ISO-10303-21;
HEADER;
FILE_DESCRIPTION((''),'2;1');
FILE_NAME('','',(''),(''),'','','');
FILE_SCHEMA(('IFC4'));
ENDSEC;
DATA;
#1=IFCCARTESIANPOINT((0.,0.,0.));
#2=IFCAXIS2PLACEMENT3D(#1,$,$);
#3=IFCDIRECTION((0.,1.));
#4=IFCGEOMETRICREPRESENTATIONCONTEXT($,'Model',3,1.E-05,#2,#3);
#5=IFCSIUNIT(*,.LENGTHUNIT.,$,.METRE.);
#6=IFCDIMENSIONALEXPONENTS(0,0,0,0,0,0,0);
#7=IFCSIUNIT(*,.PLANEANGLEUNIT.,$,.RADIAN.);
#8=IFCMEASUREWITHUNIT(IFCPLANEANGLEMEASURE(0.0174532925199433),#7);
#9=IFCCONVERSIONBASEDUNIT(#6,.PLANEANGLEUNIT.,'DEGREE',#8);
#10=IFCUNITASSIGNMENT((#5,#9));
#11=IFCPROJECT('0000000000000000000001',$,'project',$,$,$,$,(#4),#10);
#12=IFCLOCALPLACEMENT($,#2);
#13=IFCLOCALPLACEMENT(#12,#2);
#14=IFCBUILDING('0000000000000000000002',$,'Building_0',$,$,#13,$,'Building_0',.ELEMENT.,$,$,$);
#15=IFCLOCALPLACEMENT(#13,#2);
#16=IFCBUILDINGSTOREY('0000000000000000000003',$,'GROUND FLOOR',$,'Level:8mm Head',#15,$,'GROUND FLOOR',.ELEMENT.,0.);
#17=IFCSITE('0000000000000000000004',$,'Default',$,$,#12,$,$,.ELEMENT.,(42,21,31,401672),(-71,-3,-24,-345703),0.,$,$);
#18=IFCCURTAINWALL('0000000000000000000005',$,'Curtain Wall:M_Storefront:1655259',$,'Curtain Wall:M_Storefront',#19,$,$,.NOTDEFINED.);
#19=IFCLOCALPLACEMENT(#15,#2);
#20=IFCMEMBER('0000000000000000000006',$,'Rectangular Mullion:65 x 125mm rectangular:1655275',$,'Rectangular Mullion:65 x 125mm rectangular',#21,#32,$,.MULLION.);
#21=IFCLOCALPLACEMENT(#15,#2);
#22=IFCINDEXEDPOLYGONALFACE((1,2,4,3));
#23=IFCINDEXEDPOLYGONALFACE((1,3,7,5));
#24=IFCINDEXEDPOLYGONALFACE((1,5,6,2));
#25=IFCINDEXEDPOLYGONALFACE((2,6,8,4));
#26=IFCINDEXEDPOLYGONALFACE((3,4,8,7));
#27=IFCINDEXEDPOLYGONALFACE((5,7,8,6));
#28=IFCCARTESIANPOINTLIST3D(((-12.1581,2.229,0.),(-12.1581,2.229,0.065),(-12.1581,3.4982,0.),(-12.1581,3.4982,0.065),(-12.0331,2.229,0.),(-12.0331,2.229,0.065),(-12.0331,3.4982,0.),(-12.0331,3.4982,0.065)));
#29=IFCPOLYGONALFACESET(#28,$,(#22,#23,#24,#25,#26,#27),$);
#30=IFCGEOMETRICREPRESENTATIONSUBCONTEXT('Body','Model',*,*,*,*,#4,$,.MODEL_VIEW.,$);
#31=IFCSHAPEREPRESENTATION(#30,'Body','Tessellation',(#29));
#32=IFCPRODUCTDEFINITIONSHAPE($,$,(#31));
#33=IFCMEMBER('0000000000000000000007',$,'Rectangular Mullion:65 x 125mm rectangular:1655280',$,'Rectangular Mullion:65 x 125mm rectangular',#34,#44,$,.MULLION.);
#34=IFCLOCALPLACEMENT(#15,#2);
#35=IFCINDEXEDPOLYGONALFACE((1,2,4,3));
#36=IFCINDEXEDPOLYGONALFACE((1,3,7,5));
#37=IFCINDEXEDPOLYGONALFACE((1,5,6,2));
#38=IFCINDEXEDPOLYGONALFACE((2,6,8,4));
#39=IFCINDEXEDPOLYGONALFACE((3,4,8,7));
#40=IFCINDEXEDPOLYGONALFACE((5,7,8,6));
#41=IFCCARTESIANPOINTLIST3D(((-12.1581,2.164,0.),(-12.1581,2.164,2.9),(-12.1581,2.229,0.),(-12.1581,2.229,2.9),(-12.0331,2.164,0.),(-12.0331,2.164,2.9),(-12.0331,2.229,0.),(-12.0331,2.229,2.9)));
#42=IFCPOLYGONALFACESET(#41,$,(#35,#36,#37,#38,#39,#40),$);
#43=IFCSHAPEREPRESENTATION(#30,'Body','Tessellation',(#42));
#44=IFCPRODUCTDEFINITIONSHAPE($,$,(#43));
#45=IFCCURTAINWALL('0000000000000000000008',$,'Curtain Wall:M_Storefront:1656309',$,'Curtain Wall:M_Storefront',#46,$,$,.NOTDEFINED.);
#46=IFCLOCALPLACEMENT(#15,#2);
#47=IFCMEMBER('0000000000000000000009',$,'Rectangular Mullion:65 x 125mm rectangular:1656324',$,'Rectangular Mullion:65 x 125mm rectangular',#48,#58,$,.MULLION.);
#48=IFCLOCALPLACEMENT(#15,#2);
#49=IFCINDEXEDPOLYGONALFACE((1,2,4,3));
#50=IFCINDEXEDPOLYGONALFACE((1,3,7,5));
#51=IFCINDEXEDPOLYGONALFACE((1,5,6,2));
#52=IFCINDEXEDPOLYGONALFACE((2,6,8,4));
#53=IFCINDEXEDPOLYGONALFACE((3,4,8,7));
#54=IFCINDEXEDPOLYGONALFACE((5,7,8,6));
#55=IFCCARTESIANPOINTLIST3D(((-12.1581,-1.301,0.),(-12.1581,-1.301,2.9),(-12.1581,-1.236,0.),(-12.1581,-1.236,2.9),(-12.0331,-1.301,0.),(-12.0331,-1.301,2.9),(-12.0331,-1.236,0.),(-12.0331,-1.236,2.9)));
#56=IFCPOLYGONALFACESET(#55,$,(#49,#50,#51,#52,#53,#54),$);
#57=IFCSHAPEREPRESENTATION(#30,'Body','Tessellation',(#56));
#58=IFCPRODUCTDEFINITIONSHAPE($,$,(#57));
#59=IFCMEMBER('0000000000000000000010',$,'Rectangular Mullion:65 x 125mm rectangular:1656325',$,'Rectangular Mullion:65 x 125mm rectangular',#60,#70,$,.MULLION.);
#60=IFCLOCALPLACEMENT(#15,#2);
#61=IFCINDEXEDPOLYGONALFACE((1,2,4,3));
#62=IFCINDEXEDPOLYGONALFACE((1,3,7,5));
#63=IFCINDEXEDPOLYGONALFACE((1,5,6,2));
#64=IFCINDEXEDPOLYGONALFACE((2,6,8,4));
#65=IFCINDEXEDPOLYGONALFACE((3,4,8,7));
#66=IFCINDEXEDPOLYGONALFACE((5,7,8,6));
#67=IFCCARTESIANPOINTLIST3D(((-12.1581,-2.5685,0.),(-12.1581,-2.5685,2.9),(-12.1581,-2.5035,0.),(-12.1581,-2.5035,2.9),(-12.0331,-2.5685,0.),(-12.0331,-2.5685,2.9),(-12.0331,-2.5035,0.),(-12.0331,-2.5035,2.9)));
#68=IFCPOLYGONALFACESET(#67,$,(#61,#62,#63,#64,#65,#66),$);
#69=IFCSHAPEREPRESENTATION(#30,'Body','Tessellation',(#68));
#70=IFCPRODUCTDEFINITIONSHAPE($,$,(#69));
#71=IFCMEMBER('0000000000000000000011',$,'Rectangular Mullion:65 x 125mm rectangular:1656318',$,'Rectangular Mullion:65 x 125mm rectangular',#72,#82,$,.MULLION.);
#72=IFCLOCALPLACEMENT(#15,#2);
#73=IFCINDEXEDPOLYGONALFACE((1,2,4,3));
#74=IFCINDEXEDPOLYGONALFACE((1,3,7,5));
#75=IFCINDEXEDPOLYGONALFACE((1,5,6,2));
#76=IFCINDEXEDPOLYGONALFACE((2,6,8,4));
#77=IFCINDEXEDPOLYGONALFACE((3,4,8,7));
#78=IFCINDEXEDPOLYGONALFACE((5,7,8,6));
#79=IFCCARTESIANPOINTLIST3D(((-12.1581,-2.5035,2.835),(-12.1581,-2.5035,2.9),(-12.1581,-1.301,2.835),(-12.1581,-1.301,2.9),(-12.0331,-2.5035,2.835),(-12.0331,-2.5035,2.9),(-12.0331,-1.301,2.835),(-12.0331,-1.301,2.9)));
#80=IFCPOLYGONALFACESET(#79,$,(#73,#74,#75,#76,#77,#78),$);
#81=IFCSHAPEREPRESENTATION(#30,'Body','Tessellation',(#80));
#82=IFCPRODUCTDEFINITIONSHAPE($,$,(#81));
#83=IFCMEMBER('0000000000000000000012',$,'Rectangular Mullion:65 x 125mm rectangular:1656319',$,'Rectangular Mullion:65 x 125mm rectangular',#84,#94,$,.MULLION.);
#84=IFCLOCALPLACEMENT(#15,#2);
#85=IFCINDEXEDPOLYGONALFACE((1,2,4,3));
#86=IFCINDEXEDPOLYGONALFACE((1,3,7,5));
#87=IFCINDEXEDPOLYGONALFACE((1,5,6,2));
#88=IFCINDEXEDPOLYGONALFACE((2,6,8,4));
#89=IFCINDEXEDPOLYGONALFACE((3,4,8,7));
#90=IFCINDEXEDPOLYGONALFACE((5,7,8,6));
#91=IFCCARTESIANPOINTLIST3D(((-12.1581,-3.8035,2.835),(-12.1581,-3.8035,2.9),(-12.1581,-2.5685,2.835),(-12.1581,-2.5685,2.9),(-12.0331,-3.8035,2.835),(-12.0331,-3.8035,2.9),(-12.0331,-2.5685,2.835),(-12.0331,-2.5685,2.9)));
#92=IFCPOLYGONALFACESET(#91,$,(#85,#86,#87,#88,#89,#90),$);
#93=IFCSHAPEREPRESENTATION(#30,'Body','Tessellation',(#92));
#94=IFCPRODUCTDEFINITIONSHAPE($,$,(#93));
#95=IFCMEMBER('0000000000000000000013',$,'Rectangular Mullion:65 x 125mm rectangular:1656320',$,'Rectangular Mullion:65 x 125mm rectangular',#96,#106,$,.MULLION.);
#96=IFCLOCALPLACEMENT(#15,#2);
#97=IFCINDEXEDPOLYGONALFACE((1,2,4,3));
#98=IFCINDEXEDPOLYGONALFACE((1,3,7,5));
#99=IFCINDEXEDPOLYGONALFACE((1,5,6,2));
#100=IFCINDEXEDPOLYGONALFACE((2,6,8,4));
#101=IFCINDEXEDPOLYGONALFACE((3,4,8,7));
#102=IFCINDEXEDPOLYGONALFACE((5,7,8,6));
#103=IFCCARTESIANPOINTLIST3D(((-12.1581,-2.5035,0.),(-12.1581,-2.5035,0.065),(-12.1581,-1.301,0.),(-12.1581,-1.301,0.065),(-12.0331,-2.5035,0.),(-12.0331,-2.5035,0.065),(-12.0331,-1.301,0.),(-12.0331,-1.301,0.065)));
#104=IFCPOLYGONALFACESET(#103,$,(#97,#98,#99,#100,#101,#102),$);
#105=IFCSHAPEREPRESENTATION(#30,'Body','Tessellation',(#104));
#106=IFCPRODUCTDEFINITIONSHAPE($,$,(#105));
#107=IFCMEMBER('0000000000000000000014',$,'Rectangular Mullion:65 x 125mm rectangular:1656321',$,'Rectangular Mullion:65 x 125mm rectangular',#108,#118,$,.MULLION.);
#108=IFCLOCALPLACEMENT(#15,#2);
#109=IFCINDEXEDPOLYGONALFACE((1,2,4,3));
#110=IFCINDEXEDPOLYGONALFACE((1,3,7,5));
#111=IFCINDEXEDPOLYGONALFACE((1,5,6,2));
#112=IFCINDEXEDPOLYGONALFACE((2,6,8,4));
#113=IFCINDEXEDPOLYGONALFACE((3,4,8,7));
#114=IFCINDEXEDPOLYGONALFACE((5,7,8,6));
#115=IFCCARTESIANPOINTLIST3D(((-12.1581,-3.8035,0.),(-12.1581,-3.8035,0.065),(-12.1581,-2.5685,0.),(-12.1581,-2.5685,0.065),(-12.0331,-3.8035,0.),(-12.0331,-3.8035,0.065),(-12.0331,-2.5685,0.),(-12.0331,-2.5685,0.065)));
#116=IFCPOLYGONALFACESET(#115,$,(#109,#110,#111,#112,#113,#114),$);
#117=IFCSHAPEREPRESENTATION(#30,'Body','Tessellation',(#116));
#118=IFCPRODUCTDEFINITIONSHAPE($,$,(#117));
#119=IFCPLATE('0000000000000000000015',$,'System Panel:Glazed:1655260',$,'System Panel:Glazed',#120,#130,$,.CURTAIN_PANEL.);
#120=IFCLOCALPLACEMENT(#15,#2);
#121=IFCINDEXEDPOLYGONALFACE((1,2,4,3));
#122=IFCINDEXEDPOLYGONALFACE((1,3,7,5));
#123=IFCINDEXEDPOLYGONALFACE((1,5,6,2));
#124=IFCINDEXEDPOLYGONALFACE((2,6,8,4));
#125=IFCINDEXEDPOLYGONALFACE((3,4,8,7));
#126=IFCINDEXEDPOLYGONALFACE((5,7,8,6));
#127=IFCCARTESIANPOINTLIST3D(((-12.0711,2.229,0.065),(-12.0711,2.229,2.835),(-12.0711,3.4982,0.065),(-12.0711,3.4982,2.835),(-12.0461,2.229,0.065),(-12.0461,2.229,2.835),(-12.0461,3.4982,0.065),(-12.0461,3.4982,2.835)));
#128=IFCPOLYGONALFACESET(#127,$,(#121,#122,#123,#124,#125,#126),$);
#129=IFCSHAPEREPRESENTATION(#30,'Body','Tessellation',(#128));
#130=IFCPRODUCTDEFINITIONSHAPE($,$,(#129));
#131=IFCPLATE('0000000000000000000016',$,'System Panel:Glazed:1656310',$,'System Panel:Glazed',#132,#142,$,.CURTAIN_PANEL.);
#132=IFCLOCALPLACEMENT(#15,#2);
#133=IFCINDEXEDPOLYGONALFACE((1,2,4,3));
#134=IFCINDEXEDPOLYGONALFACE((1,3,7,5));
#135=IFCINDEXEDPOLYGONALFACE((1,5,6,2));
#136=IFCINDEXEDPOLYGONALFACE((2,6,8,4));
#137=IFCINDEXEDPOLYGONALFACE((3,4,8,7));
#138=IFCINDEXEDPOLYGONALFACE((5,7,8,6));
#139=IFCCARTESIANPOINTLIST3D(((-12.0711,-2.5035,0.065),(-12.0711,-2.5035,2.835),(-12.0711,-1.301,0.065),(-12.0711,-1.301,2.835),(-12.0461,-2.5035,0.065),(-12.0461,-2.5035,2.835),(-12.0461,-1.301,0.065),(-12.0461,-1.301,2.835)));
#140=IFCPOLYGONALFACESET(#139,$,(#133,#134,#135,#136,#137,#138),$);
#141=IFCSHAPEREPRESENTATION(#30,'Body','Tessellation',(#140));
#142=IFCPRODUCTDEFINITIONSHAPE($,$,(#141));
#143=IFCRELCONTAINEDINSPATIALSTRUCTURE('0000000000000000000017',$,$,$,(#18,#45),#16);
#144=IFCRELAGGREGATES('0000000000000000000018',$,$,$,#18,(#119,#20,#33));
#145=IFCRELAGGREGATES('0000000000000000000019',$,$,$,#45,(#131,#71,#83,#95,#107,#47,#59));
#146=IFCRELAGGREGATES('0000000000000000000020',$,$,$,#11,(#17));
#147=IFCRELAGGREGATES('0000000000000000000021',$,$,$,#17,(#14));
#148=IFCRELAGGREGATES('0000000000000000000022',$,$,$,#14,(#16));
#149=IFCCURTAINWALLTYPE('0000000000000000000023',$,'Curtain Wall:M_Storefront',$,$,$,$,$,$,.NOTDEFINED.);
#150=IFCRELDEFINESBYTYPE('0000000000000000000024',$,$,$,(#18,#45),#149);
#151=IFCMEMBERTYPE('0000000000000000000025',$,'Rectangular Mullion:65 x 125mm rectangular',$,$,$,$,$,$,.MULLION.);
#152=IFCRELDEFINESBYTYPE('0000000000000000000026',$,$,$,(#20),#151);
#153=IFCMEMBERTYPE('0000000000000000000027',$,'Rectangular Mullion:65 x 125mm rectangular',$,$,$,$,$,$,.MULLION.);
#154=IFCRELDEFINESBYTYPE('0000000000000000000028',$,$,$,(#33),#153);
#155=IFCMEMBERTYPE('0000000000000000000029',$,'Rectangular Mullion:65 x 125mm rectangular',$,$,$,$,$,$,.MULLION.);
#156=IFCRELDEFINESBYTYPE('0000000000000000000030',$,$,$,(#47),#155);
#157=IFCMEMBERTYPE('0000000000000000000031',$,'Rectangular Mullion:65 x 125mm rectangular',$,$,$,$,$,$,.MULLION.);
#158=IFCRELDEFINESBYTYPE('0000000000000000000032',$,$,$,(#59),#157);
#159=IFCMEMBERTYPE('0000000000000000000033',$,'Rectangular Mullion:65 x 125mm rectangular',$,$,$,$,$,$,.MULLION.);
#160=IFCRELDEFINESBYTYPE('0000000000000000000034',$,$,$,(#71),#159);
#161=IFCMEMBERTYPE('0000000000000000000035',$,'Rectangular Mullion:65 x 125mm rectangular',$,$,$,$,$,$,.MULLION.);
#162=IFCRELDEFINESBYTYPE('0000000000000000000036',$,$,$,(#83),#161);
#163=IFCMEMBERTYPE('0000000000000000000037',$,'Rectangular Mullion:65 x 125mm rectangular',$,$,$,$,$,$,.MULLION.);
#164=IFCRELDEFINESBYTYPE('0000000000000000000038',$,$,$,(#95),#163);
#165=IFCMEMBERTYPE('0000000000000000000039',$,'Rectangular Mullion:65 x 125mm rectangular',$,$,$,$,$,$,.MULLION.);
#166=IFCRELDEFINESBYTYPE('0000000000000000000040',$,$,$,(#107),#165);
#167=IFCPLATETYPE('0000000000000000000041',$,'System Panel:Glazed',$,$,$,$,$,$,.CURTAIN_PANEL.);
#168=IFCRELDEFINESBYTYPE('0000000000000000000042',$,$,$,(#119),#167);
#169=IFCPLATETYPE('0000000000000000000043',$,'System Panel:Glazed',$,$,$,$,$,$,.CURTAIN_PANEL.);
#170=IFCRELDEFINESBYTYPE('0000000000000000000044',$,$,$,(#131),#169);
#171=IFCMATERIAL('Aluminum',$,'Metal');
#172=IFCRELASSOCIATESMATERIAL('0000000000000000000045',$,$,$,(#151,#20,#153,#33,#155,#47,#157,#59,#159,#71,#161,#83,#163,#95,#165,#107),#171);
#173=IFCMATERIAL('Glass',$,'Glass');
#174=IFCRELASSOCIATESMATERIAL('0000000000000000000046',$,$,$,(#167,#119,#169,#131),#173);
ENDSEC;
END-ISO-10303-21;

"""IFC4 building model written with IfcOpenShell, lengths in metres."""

from ifc_helpers import new_model, entity, si_unit, converted_unit, direction, frame, origin, place, context, subcontext, project, spatial, indexed_curve, outline, extrude, source, transform, mapped, material, type_object, type_shapes, element, aggregate, save


model = new_model("IFC4")

# Units and contexts
model_context = context("Model", 3, precision=1e-05, world=origin(), true_north=direction((0.0, 1.0)))
body_context = subcontext(model_context, "Body", "Model", "MODEL_VIEW")
ifc_project = project(units=[si_unit("LENGTHUNIT", "METRE"), converted_unit("PLANEANGLEUNIT", "DEGREE", entity("IfcPlaneAngleMeasure", 0.0174532925199433), si_unit("PLANEANGLEUNIT", "RADIAN"), dimensions=[0, 0, 0, 0, 0, 0, 0])], contexts=[model_context])

# Site, building, storey
site_placement = place(None, origin())
site = spatial("IfcSite", under=ifc_project, at=site_placement, Name="Default", CompositionType="ELEMENT", RefLatitude=(42, 21, 31, 401672), RefLongitude=(-71, -3, -24, -345703), RefElevation=0.0)
building_placement = place(site_placement, origin())
building = spatial("IfcBuilding", under=site, at=building_placement, Name="Building_0", LongName="Building_0", CompositionType="ELEMENT")
storey_placement = place(building_placement, origin())
storey = spatial("IfcBuildingStorey", under=building, at=storey_placement, Name="GROUND FLOOR", ObjectType="Level:8mm Head", LongName="GROUND FLOOR", CompositionType="ELEMENT", Elevation=0.0)

# Curtain walls, members
curtain_wall_type = type_object("IfcCurtainWallType", Name="Curtain Wall:M_Storefront", PredefinedType="NOTDEFINED")
curtain_wall_1_placement = place(storey_placement, origin())
curtain_wall_1 = element("IfcCurtainWall", 1, at=curtain_wall_1_placement, inside=storey, type_object=curtain_wall_type, Name="Curtain Wall:M_Storefront:1655259", ObjectType="Curtain Wall:M_Storefront", PredefinedType="NOTDEFINED")
ifc_material_1 = material(Name="Aluminum", Category="Metal")
member_type_1 = type_object("IfcMemberType", Name="Rectangular Mullion:65 x 125mm rectangular", PredefinedType="MULLION", material=ifc_material_1)
shared_shape_1 = source(origin(), body_context, "Body", "SweptSolid", [
    extrude(outline(indexed_curve([(-0.0325, -0.0625), (0.0325, -0.0625), (0.0325, 0.0625), (-0.0325, 0.0625), (-0.0325, -0.0625)], self_intersect=False)), frame((-0.0325, 0.0, -1.2692), z_axis=(0.0, 0.0, 1.0), x_axis=(-1.0, 0.0, 0.0)), (0.0, 0.0, 1.0), 1.2692),
])
type_shapes(member_type_1, [shared_shape_1])
member_1_placement = place(curtain_wall_1_placement, frame((-12.0956, 2.229, 0.0), z_axis=(0.0, -1.0, 0.0), x_axis=(0.0, 0.0, -1.0)))
member_1 = element("IfcMember", 2, at=member_1_placement, type_object=member_type_1, material=ifc_material_1, Name="Rectangular Mullion:65 x 125mm rectangular:1655275", ObjectType="Rectangular Mullion:65 x 125mm rectangular", PredefinedType="MULLION", context=body_context, shape_type="MappedRepresentation", body=[
    mapped(shared_shape_1, transform((0.0, 0.0, 0.0), scale=1.0)),
])
member_type_2 = type_object("IfcMemberType", Name="Rectangular Mullion:65 x 125mm rectangular", PredefinedType="MULLION", material=ifc_material_1)
shared_shape_2 = source(origin(), body_context, "Body", "SweptSolid", [
    extrude(outline(indexed_curve([(-0.0325, -0.0625), (0.0325, -0.0625), (0.0325, 0.0625), (-0.0325, 0.0625), (-0.0325, -0.0625)], self_intersect=False)), frame((-0.0325, 0.0, -2.9), z_axis=(0.0, 0.0, 1.0), x_axis=(-1.0, 0.0, 0.0)), (0.0, 0.0, 1.0), 2.9),
])
type_shapes(member_type_2, [shared_shape_2])
member_2_placement = place(curtain_wall_1_placement, frame((-12.0956, 2.164, 2.9), z_axis=(0.0, 0.0, 1.0), x_axis=(0.0, -1.0, 0.0)))
member_2 = element("IfcMember", 3, at=member_2_placement, type_object=member_type_2, material=ifc_material_1, Name="Rectangular Mullion:65 x 125mm rectangular:1655280", ObjectType="Rectangular Mullion:65 x 125mm rectangular", PredefinedType="MULLION", context=body_context, shape_type="MappedRepresentation", body=[
    mapped(shared_shape_2, transform((0.0, 0.0, 0.0), scale=1.0)),
])
curtain_wall_2_placement = place(storey_placement, origin())
curtain_wall_2 = element("IfcCurtainWall", 4, at=curtain_wall_2_placement, inside=storey, type_object=curtain_wall_type, Name="Curtain Wall:M_Storefront:1656309", ObjectType="Curtain Wall:M_Storefront", PredefinedType="NOTDEFINED")
member_type_3 = type_object("IfcMemberType", Name="Rectangular Mullion:65 x 125mm rectangular", PredefinedType="MULLION", material=ifc_material_1)
shared_shape_3 = source(origin(), body_context, "Body", "SweptSolid", [
    extrude(outline(indexed_curve([(-0.0325, -0.0625), (0.0325, -0.0625), (0.0325, 0.0625), (-0.0325, 0.0625), (-0.0325, -0.0625)], self_intersect=False)), frame((-0.0325, 0.0, -2.9), z_axis=(0.0, 0.0, 1.0), x_axis=(-1.0, 0.0, 0.0)), (0.0, 0.0, 1.0), 2.9),
])
type_shapes(member_type_3, [shared_shape_3])
member_3_placement = place(curtain_wall_2_placement, frame((-12.0956, -1.236, 2.9), z_axis=(0.0, 0.0, 1.0), x_axis=(0.0, 1.0, 0.0)))
member_3 = element("IfcMember", 5, at=member_3_placement, type_object=member_type_3, material=ifc_material_1, Name="Rectangular Mullion:65 x 125mm rectangular:1656324", ObjectType="Rectangular Mullion:65 x 125mm rectangular", PredefinedType="MULLION", context=body_context, shape_type="MappedRepresentation", body=[
    mapped(shared_shape_3, transform((0.0, 0.0, 0.0), scale=1.0)),
])
member_type_4 = type_object("IfcMemberType", Name="Rectangular Mullion:65 x 125mm rectangular", PredefinedType="MULLION", material=ifc_material_1)
shared_shape_4 = source(origin(), body_context, "Body", "SweptSolid", [
    extrude(outline(indexed_curve([(-0.0325, -0.0625), (0.0325, -0.0625), (0.0325, 0.0625), (-0.0325, 0.0625), (-0.0325, -0.0625)], self_intersect=False)), frame((0.0, 0.0, -2.9), z_axis=(0.0, 0.0, 1.0), x_axis=(-1.0, 0.0, 0.0)), (0.0, 0.0, 1.0), 2.9),
])
type_shapes(member_type_4, [shared_shape_4])
member_4_placement = place(curtain_wall_2_placement, frame((-12.0956, -2.536, 0.0), z_axis=(0.0, 0.0, -1.0), x_axis=(0.0, -1.0, 0.0)))
member_4 = element("IfcMember", 6, at=member_4_placement, type_object=member_type_4, material=ifc_material_1, Name="Rectangular Mullion:65 x 125mm rectangular:1656325", ObjectType="Rectangular Mullion:65 x 125mm rectangular", PredefinedType="MULLION", context=body_context, shape_type="MappedRepresentation", body=[
    mapped(shared_shape_4, transform((0.0, 0.0, 0.0), scale=1.0)),
])
member_type_5 = type_object("IfcMemberType", Name="Rectangular Mullion:65 x 125mm rectangular", PredefinedType="MULLION", material=ifc_material_1)
shared_shape_5 = source(origin(), body_context, "Body", "SweptSolid", [
    extrude(outline(indexed_curve([(-0.0325, -0.0625), (0.0325, -0.0625), (0.0325, 0.0625), (-0.0325, 0.0625), (-0.0325, -0.0625)], self_intersect=False)), frame((-0.0325, 0.0, -1.2025), z_axis=(0.0, 0.0, 1.0), x_axis=(-1.0, 0.0, 0.0)), (0.0, 0.0, 1.0), 1.2025),
])
type_shapes(member_type_5, [shared_shape_5])
member_5_placement = place(curtain_wall_2_placement, frame((-12.0956, -2.5035, 2.9), z_axis=(0.0, -1.0, 0.0), x_axis=(0.0, 0.0, 1.0)))
member_5 = element("IfcMember", 7, at=member_5_placement, type_object=member_type_5, material=ifc_material_1, Name="Rectangular Mullion:65 x 125mm rectangular:1656318", ObjectType="Rectangular Mullion:65 x 125mm rectangular", PredefinedType="MULLION", context=body_context, shape_type="MappedRepresentation", body=[
    mapped(shared_shape_5, transform((0.0, 0.0, 0.0), scale=1.0)),
])
member_type_6 = type_object("IfcMemberType", Name="Rectangular Mullion:65 x 125mm rectangular", PredefinedType="MULLION", material=ifc_material_1)
shared_shape_6 = source(origin(), body_context, "Body", "SweptSolid", [
    extrude(outline(indexed_curve([(-0.0325, -0.0625), (0.0325, -0.0625), (0.0325, 0.0625), (-0.0325, 0.0625), (-0.0325, -0.0625)], self_intersect=False)), frame((-0.0325, 0.0, -1.235), z_axis=(0.0, 0.0, 1.0), x_axis=(-1.0, 0.0, 0.0)), (0.0, 0.0, 1.0), 1.235),
])
type_shapes(member_type_6, [shared_shape_6])
member_6_placement = place(curtain_wall_2_placement, frame((-12.0956, -3.8035, 2.9), z_axis=(0.0, -1.0, 0.0), x_axis=(0.0, 0.0, 1.0)))
member_6 = element("IfcMember", 8, at=member_6_placement, type_object=member_type_6, material=ifc_material_1, Name="Rectangular Mullion:65 x 125mm rectangular:1656319", ObjectType="Rectangular Mullion:65 x 125mm rectangular", PredefinedType="MULLION", context=body_context, shape_type="MappedRepresentation", body=[
    mapped(shared_shape_6, transform((0.0, 0.0, 0.0), scale=1.0)),
])
member_type_7 = type_object("IfcMemberType", Name="Rectangular Mullion:65 x 125mm rectangular", PredefinedType="MULLION", material=ifc_material_1)
shared_shape_7 = source(origin(), body_context, "Body", "SweptSolid", [
    extrude(outline(indexed_curve([(-0.0325, -0.0625), (0.0325, -0.0625), (0.0325, 0.0625), (-0.0325, 0.0625), (-0.0325, -0.0625)], self_intersect=False)), frame((-0.0325, 0.0, -1.2025), z_axis=(0.0, 0.0, 1.0), x_axis=(-1.0, 0.0, 0.0)), (0.0, 0.0, 1.0), 1.2025),
])
type_shapes(member_type_7, [shared_shape_7])
member_7_placement = place(curtain_wall_2_placement, frame((-12.0956, -1.301, 0.0), z_axis=(0.0, 1.0, 0.0), x_axis=(0.0, 0.0, -1.0)))
member_7 = element("IfcMember", 9, at=member_7_placement, type_object=member_type_7, material=ifc_material_1, Name="Rectangular Mullion:65 x 125mm rectangular:1656320", ObjectType="Rectangular Mullion:65 x 125mm rectangular", PredefinedType="MULLION", context=body_context, shape_type="MappedRepresentation", body=[
    mapped(shared_shape_7, transform((0.0, 0.0, 0.0), scale=1.0)),
])
member_type_8 = type_object("IfcMemberType", Name="Rectangular Mullion:65 x 125mm rectangular", PredefinedType="MULLION", material=ifc_material_1)
shared_shape_8 = source(origin(), body_context, "Body", "SweptSolid", [
    extrude(outline(indexed_curve([(-0.0325, -0.0625), (0.0325, -0.0625), (0.0325, 0.0625), (-0.0325, 0.0625), (-0.0325, -0.0625)], self_intersect=False)), frame((-0.0325, 0.0, -1.235), z_axis=(0.0, 0.0, 1.0), x_axis=(-1.0, 0.0, 0.0)), (0.0, 0.0, 1.0), 1.235),
])
type_shapes(member_type_8, [shared_shape_8])
member_8_placement = place(curtain_wall_2_placement, frame((-12.0956, -2.5685, 0.0), z_axis=(0.0, 1.0, 0.0), x_axis=(0.0, 0.0, -1.0)))
member_8 = element("IfcMember", 10, at=member_8_placement, type_object=member_type_8, material=ifc_material_1, Name="Rectangular Mullion:65 x 125mm rectangular:1656321", ObjectType="Rectangular Mullion:65 x 125mm rectangular", PredefinedType="MULLION", context=body_context, shape_type="MappedRepresentation", body=[
    mapped(shared_shape_8, transform((0.0, 0.0, 0.0), scale=1.0)),
])

# Plates
ifc_material_2 = material(Name="Glass", Category="Glass")
plate_type_1 = type_object("IfcPlateType", Name="System Panel:Glazed", PredefinedType="CURTAIN_PANEL", material=ifc_material_2)
shared_shape_9 = source(origin(), body_context, "Body", "SweptSolid", [
    extrude(outline(indexed_curve([(-0.0125, -0.6346), (0.0125, -0.6346), (0.0125, 0.6346), (-0.0125, 0.6346), (-0.0125, -0.6346)], self_intersect=False)), frame((0.0, -0.037, 0.0), z_axis=(0.0, 0.0, 1.0), x_axis=(0.0, 1.0, 0.0)), (0.0, 0.0, 1.0), 2.77),
])
type_shapes(plate_type_1, [shared_shape_9])
plate_1_placement = place(curtain_wall_1_placement, frame((-12.0956, 2.8636, 0.065), z_axis=(0.0, 0.0, 1.0), x_axis=(0.0, 1.0, 0.0)))
plate_1 = element("IfcPlate", 11, at=plate_1_placement, type_object=plate_type_1, material=ifc_material_2, Name="System Panel:Glazed:1655260", ObjectType="System Panel:Glazed", PredefinedType="CURTAIN_PANEL", context=body_context, shape_type="MappedRepresentation", body=[
    mapped(shared_shape_9, transform((0.0, 0.0, 0.0), scale=1.0)),
])
aggregate(curtain_wall_1, [plate_1, member_1, member_2])
plate_type_2 = type_object("IfcPlateType", Name="System Panel:Glazed", PredefinedType="CURTAIN_PANEL", material=ifc_material_2)
shared_shape_10 = source(origin(), body_context, "Body", "SweptSolid", [
    extrude(outline(indexed_curve([(-0.0125, -0.6013), (0.0125, -0.6013), (0.0125, 0.6013), (-0.0125, 0.6013), (-0.0125, -0.6013)], self_intersect=False)), frame((0.0, 0.037, 0.0), z_axis=(0.0, 0.0, 1.0), x_axis=(0.0, 1.0, 0.0)), (0.0, 0.0, 1.0), 2.77),
])
type_shapes(plate_type_2, [shared_shape_10])
plate_2_placement = place(curtain_wall_2_placement, frame((-12.0956, -1.9023, 0.065), z_axis=(0.0, 0.0, 1.0), x_axis=(0.0, -1.0, 0.0)))
plate_2 = element("IfcPlate", 12, at=plate_2_placement, type_object=plate_type_2, material=ifc_material_2, Name="System Panel:Glazed:1656310", ObjectType="System Panel:Glazed", PredefinedType="CURTAIN_PANEL", context=body_context, shape_type="MappedRepresentation", body=[
    mapped(shared_shape_10, transform((0.0, 0.0, 0.0), scale=1.0)),
])
aggregate(curtain_wall_2, [plate_2, member_5, member_6, member_7, member_8, member_3, member_4])

save(model, "model.ifc")
